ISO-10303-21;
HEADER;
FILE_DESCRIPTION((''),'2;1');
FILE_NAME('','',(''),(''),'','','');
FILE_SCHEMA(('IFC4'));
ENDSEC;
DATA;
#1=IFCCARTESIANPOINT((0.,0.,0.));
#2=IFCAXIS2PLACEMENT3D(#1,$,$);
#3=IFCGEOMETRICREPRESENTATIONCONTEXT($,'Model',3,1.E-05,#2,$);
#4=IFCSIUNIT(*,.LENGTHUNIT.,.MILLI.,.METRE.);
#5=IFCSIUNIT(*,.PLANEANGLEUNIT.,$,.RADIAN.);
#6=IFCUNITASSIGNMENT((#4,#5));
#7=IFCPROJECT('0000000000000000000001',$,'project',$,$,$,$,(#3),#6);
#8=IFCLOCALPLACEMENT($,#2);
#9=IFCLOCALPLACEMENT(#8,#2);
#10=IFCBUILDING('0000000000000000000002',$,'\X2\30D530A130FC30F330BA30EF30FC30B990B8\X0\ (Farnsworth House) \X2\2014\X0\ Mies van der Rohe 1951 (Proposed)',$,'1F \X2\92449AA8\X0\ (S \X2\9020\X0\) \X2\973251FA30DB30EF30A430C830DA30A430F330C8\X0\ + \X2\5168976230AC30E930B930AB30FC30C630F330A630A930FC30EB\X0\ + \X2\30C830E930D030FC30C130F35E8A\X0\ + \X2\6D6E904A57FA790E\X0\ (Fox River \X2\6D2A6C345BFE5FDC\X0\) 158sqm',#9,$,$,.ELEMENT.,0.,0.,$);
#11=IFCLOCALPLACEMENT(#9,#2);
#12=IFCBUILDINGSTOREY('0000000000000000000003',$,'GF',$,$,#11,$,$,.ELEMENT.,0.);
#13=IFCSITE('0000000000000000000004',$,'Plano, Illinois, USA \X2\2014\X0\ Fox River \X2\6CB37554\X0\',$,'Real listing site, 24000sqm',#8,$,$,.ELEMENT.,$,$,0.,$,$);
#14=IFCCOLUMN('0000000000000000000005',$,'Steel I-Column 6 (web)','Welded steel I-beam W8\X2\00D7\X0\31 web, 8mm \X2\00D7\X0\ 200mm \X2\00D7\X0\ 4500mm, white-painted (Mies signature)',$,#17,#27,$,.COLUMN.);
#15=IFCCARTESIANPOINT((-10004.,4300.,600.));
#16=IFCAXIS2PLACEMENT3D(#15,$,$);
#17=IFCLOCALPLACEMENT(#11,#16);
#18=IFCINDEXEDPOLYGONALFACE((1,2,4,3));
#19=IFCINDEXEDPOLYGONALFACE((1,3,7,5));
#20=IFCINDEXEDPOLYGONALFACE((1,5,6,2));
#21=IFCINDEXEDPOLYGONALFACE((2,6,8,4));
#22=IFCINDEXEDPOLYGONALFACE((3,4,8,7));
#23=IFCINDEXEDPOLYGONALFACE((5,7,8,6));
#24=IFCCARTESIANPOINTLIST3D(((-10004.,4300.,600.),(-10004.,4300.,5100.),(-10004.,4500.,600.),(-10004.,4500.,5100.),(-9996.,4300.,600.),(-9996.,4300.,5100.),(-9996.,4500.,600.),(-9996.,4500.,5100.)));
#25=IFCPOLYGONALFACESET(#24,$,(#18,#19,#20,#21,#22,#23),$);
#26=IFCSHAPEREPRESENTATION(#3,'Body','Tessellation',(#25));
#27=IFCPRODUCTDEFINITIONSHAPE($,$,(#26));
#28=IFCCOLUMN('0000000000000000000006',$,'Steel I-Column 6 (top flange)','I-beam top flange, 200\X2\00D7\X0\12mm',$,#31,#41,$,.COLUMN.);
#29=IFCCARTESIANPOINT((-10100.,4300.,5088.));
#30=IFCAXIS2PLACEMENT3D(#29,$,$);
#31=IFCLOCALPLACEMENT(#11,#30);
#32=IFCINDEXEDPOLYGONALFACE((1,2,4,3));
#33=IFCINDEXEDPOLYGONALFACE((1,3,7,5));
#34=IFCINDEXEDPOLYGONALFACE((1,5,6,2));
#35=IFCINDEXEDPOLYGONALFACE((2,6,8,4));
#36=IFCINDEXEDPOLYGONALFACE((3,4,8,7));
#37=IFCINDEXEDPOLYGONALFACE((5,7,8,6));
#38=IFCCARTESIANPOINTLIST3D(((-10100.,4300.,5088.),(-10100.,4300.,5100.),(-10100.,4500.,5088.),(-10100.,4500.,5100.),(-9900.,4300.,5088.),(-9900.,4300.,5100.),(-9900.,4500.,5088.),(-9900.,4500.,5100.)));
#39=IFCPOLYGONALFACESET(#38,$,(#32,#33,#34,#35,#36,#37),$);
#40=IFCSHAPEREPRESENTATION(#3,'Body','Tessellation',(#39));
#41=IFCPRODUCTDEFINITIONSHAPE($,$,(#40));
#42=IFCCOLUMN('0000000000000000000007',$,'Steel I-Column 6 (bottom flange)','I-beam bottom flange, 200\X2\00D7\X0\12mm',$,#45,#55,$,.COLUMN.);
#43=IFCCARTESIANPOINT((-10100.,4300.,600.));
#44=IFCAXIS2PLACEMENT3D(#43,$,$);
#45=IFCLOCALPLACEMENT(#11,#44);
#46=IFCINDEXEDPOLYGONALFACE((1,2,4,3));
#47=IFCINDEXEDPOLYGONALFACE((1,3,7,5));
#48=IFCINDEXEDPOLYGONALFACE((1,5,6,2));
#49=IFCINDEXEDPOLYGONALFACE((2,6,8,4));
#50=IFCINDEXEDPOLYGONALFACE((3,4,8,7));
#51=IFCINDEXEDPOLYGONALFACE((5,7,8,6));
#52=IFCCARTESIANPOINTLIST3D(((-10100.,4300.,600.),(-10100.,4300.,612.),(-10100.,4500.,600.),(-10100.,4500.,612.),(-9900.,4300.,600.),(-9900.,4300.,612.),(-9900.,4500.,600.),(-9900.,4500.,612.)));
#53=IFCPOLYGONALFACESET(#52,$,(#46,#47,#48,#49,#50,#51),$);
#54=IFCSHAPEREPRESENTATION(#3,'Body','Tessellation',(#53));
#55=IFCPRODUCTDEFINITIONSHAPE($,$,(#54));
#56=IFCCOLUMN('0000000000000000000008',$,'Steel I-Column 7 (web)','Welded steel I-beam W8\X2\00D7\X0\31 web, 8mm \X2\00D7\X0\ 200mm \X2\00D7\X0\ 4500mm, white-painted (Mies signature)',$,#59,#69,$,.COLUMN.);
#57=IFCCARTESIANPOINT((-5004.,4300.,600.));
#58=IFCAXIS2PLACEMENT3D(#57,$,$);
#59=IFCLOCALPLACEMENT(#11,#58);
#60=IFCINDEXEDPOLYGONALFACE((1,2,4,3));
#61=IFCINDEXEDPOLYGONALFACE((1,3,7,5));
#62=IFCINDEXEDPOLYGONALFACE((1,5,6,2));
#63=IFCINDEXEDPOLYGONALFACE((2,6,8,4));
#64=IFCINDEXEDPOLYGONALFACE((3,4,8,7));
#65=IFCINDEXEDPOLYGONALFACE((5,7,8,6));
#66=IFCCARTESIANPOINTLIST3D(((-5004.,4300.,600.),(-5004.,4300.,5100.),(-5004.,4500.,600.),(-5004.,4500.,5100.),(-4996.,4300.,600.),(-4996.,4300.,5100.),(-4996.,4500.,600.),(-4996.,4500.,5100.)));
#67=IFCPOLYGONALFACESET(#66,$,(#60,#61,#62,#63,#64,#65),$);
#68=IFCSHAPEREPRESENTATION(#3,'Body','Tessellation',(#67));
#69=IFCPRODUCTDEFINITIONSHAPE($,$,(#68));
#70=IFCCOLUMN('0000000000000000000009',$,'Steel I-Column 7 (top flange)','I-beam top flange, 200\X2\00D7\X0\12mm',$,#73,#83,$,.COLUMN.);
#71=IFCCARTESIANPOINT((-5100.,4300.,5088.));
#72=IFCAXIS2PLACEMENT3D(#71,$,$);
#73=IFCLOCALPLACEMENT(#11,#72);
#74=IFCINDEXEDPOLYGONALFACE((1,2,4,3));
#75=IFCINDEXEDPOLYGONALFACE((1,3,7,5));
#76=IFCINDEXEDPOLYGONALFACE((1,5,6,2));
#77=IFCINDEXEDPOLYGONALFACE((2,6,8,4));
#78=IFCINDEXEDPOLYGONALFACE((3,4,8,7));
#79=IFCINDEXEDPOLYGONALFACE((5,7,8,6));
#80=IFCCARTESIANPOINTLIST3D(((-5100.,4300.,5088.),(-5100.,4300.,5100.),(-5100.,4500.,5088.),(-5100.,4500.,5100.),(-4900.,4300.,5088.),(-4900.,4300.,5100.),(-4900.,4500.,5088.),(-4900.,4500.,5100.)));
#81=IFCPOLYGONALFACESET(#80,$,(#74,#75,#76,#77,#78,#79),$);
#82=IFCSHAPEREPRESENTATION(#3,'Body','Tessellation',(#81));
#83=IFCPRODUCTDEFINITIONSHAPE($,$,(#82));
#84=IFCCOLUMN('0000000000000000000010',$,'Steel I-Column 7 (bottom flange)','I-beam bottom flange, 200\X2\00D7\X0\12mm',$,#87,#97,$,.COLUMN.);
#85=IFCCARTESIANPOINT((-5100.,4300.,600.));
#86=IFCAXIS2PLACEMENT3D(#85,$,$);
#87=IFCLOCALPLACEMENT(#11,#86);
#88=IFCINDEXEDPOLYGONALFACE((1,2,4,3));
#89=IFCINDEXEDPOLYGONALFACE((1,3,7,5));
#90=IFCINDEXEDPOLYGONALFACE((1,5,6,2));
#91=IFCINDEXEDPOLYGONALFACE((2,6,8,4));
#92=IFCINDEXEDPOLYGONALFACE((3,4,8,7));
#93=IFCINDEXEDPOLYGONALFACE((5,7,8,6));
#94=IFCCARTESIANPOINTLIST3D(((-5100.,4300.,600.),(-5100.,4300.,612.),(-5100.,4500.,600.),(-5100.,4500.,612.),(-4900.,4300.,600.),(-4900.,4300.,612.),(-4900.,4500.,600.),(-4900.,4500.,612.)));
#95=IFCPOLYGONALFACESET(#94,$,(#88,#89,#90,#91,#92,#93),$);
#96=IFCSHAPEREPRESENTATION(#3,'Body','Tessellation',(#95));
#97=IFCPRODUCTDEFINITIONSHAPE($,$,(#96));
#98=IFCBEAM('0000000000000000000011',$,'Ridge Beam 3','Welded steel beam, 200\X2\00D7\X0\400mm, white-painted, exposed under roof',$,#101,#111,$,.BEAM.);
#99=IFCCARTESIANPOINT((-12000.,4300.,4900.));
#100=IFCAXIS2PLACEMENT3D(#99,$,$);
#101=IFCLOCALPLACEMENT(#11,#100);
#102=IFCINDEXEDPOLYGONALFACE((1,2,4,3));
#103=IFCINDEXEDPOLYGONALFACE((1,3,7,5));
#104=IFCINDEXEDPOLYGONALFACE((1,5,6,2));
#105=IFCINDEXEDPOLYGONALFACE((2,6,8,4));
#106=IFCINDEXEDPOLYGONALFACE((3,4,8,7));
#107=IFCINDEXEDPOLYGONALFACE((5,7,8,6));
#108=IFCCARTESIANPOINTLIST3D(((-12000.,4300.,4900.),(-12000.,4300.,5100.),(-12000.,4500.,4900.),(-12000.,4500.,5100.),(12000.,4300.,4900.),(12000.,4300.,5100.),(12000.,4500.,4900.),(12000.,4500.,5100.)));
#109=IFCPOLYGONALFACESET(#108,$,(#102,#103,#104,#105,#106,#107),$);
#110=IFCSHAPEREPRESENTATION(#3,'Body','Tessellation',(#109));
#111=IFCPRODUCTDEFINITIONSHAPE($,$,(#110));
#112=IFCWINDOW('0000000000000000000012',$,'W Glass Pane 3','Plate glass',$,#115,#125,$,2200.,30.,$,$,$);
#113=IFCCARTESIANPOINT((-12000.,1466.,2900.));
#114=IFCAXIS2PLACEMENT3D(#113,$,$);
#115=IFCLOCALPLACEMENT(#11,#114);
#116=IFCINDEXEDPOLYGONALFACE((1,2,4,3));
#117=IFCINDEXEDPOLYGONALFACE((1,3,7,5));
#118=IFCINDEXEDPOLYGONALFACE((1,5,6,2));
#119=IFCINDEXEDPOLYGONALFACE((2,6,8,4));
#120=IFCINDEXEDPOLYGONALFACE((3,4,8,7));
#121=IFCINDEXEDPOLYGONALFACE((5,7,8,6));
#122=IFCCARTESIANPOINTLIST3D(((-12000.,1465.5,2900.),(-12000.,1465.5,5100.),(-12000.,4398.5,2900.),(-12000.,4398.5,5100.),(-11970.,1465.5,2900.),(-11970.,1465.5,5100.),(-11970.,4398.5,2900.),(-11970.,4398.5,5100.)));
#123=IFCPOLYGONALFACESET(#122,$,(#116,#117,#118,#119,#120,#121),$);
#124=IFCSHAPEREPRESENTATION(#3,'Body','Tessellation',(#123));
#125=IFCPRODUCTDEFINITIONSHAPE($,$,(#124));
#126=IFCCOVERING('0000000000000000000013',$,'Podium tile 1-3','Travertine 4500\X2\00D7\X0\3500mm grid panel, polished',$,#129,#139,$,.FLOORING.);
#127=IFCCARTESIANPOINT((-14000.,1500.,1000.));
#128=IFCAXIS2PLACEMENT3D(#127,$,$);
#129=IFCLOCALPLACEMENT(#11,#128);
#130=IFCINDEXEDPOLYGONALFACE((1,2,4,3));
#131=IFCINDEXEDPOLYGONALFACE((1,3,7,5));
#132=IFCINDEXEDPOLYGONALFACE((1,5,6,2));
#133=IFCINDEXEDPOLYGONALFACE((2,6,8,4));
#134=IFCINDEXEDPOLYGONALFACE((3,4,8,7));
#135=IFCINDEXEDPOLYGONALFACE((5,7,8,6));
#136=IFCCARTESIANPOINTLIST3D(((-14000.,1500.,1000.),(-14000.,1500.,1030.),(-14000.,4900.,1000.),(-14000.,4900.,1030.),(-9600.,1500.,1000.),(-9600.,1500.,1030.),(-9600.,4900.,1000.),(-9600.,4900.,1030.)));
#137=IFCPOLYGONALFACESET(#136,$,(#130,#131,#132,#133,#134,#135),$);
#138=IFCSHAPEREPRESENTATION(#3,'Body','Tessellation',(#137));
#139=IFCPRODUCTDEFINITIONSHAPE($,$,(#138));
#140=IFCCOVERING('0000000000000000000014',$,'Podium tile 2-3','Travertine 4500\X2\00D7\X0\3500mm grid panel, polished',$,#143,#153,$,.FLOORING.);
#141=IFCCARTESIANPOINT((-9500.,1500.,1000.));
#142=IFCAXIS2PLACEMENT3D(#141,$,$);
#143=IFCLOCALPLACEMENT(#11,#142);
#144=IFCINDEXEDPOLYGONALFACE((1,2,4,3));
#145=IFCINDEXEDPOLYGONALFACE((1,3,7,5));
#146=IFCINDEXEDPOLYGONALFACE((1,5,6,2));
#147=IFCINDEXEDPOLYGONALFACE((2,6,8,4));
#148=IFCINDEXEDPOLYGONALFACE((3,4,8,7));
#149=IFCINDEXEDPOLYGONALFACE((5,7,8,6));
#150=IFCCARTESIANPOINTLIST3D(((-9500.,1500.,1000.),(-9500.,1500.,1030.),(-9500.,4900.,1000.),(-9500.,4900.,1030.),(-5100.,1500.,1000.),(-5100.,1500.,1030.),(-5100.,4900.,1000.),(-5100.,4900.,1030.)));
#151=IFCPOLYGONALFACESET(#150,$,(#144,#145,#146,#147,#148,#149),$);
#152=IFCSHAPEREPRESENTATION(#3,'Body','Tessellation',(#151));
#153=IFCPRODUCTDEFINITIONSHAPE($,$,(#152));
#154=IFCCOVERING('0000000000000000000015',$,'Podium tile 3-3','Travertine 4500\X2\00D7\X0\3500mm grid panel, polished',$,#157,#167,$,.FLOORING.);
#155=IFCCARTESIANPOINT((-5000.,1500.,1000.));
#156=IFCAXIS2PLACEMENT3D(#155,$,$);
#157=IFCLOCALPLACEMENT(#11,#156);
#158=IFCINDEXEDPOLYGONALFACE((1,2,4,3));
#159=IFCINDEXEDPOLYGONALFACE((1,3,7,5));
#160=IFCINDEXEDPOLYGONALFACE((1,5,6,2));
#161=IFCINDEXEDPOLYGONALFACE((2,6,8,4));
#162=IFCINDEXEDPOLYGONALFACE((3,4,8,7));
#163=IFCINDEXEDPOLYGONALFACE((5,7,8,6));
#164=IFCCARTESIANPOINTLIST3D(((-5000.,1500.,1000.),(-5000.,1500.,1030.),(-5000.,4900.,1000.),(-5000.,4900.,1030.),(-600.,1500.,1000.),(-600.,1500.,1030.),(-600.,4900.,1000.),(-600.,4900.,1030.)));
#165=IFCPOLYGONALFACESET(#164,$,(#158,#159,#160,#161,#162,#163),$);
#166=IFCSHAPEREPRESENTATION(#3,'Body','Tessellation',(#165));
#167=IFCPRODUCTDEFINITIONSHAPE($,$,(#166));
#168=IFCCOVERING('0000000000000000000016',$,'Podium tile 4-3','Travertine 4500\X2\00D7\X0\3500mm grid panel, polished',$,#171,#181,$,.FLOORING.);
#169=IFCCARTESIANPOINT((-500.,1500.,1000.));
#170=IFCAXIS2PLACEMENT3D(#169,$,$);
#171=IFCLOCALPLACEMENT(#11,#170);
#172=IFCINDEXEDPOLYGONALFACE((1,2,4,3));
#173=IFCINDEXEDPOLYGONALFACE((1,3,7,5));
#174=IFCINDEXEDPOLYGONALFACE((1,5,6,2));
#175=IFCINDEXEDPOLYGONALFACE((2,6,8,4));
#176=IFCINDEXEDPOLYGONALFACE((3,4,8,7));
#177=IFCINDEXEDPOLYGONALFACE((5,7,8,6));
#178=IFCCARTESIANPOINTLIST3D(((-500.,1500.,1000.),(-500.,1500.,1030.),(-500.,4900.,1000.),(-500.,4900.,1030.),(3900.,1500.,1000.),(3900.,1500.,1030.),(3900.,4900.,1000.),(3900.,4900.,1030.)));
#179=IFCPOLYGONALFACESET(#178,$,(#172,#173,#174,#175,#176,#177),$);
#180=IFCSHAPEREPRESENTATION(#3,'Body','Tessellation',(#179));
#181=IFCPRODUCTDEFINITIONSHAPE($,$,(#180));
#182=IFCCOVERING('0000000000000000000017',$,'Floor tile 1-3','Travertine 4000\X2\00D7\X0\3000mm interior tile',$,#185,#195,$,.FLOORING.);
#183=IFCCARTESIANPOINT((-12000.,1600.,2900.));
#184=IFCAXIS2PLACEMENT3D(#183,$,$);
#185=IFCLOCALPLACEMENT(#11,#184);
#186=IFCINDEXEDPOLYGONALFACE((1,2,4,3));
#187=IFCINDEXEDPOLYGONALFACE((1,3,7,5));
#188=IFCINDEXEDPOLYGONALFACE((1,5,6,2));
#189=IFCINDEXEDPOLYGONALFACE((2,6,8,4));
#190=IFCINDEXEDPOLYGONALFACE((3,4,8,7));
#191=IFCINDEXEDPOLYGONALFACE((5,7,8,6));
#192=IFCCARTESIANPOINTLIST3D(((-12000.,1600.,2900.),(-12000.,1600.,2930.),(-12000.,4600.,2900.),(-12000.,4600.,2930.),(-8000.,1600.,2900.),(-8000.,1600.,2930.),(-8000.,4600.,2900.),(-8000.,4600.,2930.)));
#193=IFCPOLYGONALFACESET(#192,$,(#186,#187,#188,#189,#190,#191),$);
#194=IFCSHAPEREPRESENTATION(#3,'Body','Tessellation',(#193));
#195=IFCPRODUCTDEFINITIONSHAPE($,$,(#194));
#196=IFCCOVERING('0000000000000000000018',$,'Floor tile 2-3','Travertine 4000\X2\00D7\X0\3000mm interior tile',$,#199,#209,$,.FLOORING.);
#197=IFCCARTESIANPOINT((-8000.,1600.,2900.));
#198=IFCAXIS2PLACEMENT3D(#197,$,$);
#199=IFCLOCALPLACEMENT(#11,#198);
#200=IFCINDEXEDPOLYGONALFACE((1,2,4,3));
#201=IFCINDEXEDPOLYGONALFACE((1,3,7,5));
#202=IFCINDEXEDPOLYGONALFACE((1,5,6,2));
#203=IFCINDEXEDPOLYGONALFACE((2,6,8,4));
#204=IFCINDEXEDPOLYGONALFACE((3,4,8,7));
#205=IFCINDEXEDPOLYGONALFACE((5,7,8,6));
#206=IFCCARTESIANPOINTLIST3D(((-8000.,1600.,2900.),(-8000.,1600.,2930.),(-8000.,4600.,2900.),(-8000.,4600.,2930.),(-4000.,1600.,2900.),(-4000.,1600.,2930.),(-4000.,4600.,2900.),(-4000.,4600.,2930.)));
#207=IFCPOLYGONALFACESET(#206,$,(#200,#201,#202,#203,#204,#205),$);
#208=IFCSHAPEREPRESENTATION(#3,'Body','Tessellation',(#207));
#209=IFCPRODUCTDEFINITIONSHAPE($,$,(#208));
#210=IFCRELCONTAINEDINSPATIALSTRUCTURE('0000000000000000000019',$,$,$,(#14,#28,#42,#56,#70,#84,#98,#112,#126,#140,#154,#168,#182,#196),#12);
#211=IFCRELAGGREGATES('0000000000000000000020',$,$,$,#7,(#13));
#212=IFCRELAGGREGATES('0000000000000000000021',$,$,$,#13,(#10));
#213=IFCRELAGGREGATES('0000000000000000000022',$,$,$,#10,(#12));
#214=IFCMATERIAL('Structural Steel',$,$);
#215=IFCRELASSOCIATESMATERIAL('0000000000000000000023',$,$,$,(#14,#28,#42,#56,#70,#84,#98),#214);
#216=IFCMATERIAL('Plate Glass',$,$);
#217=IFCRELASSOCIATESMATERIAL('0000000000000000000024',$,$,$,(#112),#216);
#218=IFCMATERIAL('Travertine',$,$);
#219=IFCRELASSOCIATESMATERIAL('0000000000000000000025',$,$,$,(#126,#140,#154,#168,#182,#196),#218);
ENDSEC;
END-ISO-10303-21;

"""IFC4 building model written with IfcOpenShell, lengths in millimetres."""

from ifc_helpers import new_model, si_unit, frame, frame_2d, origin, place, context, project, spatial, rectangle, extrude, material, element, save


model = new_model("IFC4")

# Units and contexts
model_context = context("Model", 3, precision=1e-05, world=origin())
ifc_project = project(units=[si_unit("LENGTHUNIT", "METRE", prefix="MILLI"), si_unit("PLANEANGLEUNIT", "RADIAN")], contexts=[model_context])

# Site, building, storey
site_placement = place(None, origin())
site = spatial("IfcSite", under=ifc_project, at=site_placement, Name="Plano, Illinois, USA — Fox River 河畔", ObjectType="Real listing site, 24000sqm", CompositionType="ELEMENT", RefElevation=0.0)
building_placement = place(site_placement, origin())
building = spatial("IfcBuilding", under=site, at=building_placement, Name="ファーンズワース邸 (Farnsworth House) — Mies van der Rohe 1951 (Proposed)", ObjectType="1F 鉄骨 (S 造) 露出ホワイトペイント + 全面ガラスカーテンウォール + トラバーチン床 + 浮遊基礎 (Fox River 洪水対応) 158sqm", CompositionType="ELEMENT", ElevationOfRefHeight=0.0, ElevationOfTerrain=0.0)
storey_placement = place(building_placement, origin())
storey = spatial("IfcBuildingStorey", under=building, at=storey_placement, Name="GF", CompositionType="ELEMENT", Elevation=0.0)

# Columns
ifc_material_1 = material(Name="Structural Steel")
column_1_placement = place(storey_placement, frame((-10004.0, 4300.0, 600.0)))
element("IfcColumn", 1, at=column_1_placement, inside=storey, material=ifc_material_1, Name="Steel I-Column 6 (web)", Description="Welded steel I-beam W8×31 web, 8mm × 200mm × 4500mm, white-painted (Mies signature)", PredefinedType="COLUMN", context=model_context, shape_type="SweptSolid", body=[
    extrude(rectangle(XDim=8.0, YDim=200.0, at=frame_2d((4.0, 100.0))), frame((-10004.0, 4300.0, 600.0)), (0.0, 0.0, 1.0), 4500.0),
])
column_2_placement = place(storey_placement, frame((-10100.0, 4300.0, 5088.0)))
element("IfcColumn", 2, at=column_2_placement, inside=storey, material=ifc_material_1, Name="Steel I-Column 6 (top flange)", Description="I-beam top flange, 200×12mm", PredefinedType="COLUMN", context=model_context, shape_type="SweptSolid", body=[
    extrude(rectangle(XDim=200.0, YDim=200.0, at=frame_2d((100.0, 100.0))), frame((-10100.0, 4300.0, 5088.0)), (0.0, 0.0, 1.0), 12.0),
])
column_3_placement = place(storey_placement, frame((-10100.0, 4300.0, 600.0)))
element("IfcColumn", 3, at=column_3_placement, inside=storey, material=ifc_material_1, Name="Steel I-Column 6 (bottom flange)", Description="I-beam bottom flange, 200×12mm", PredefinedType="COLUMN", context=model_context, shape_type="SweptSolid", body=[
    extrude(rectangle(XDim=200.0, YDim=200.0, at=frame_2d((100.0, 100.0))), frame((-10100.0, 4300.0, 600.0)), (0.0, 0.0, 1.0), 12.0),
])
column_4_placement = place(storey_placement, frame((-5004.0, 4300.0, 600.0)))
element("IfcColumn", 4, at=column_4_placement, inside=storey, material=ifc_material_1, Name="Steel I-Column 7 (web)", Description="Welded steel I-beam W8×31 web, 8mm × 200mm × 4500mm, white-painted (Mies signature)", PredefinedType="COLUMN", context=model_context, shape_type="SweptSolid", body=[
    extrude(rectangle(XDim=8.0, YDim=200.0, at=frame_2d((4.0, 100.0))), frame((-5004.0, 4300.0, 600.0)), (0.0, 0.0, 1.0), 4500.0),
])
column_5_placement = place(storey_placement, frame((-5100.0, 4300.0, 5088.0)))
element("IfcColumn", 5, at=column_5_placement, inside=storey, material=ifc_material_1, Name="Steel I-Column 7 (top flange)", Description="I-beam top flange, 200×12mm", PredefinedType="COLUMN", context=model_context, shape_type="SweptSolid", body=[
    extrude(rectangle(XDim=200.0, YDim=200.0, at=frame_2d((100.0, 100.0))), frame((-5100.0, 4300.0, 5088.0)), (0.0, 0.0, 1.0), 12.0),
])
column_6_placement = place(storey_placement, frame((-5100.0, 4300.0, 600.0)))
element("IfcColumn", 6, at=column_6_placement, inside=storey, material=ifc_material_1, Name="Steel I-Column 7 (bottom flange)", Description="I-beam bottom flange, 200×12mm", PredefinedType="COLUMN", context=model_context, shape_type="SweptSolid", body=[
    extrude(rectangle(XDim=200.0, YDim=200.0, at=frame_2d((100.0, 100.0))), frame((-5100.0, 4300.0, 600.0)), (0.0, 0.0, 1.0), 12.0),
])

# Beam
beam_1_placement = place(storey_placement, frame((-12000.0, 4300.0, 4900.0)))
element("IfcBeam", 7, at=beam_1_placement, inside=storey, material=ifc_material_1, Name="Ridge Beam 3", Description="Welded steel beam, 200×400mm, white-painted, exposed under roof", PredefinedType="BEAM", context=model_context, shape_type="SweptSolid", body=[
    extrude(rectangle(XDim=24000.0, YDim=200.0, at=frame_2d((12000.0, 100.0))), frame((-12000.0, 4300.0, 4900.0)), (0.0, 0.0, 1.0), 200.0),
])

# Window
ifc_material_2 = material(Name="Plate Glass")
window_placement = place(storey_placement, frame((-12000.0, 1466.0, 2900.0)))
element("IfcWindow", 8, at=window_placement, inside=storey, material=ifc_material_2, Name="W Glass Pane 3", Description="Plate glass", OverallHeight=2200.0, OverallWidth=30.0, context=model_context, shape_type="SweptSolid", body=[
    extrude(rectangle(XDim=30.0, YDim=2933.0, at=frame_2d((15.0, 1466.0))), frame((-12000.0, 1466.0, 2900.0)), (0.0, 0.0, 1.0), 2200.0),
])

# Coverings
ifc_material_3 = material(Name="Travertine")
covering_1_placement = place(storey_placement, frame((-14000.0, 1500.0, 1000.0)))
element("IfcCovering", 9, at=covering_1_placement, inside=storey, material=ifc_material_3, Name="Podium tile 1-3", Description="Travertine 4500×3500mm grid panel, polished", PredefinedType="FLOORING", context=model_context, shape_type="SweptSolid", body=[
    extrude(rectangle(XDim=4400.0, YDim=3400.0, at=frame_2d((2200.0, 1700.0))), frame((-14000.0, 1500.0, 1000.0)), (0.0, 0.0, 1.0), 30.0),
])
covering_2_placement = place(storey_placement, frame((-9500.0, 1500.0, 1000.0)))
element("IfcCovering", 10, at=covering_2_placement, inside=storey, material=ifc_material_3, Name="Podium tile 2-3", Description="Travertine 4500×3500mm grid panel, polished", PredefinedType="FLOORING", context=model_context, shape_type="SweptSolid", body=[
    extrude(rectangle(XDim=4400.0, YDim=3400.0, at=frame_2d((2200.0, 1700.0))), frame((-9500.0, 1500.0, 1000.0)), (0.0, 0.0, 1.0), 30.0),
])
covering_3_placement = place(storey_placement, frame((-5000.0, 1500.0, 1000.0)))
element("IfcCovering", 11, at=covering_3_placement, inside=storey, material=ifc_material_3, Name="Podium tile 3-3", Description="Travertine 4500×3500mm grid panel, polished", PredefinedType="FLOORING", context=model_context, shape_type="SweptSolid", body=[
    extrude(rectangle(XDim=4400.0, YDim=3400.0, at=frame_2d((2200.0, 1700.0))), frame((-5000.0, 1500.0, 1000.0)), (0.0, 0.0, 1.0), 30.0),
])
covering_4_placement = place(storey_placement, frame((-500.0, 1500.0, 1000.0)))
element("IfcCovering", 12, at=covering_4_placement, inside=storey, material=ifc_material_3, Name="Podium tile 4-3", Description="Travertine 4500×3500mm grid panel, polished", PredefinedType="FLOORING", context=model_context, shape_type="SweptSolid", body=[
    extrude(rectangle(XDim=4400.0, YDim=3400.0, at=frame_2d((2200.0, 1700.0))), frame((-500.0, 1500.0, 1000.0)), (0.0, 0.0, 1.0), 30.0),
])
covering_5_placement = place(storey_placement, frame((-12000.0, 1600.0, 2900.0)))
element("IfcCovering", 13, at=covering_5_placement, inside=storey, material=ifc_material_3, Name="Floor tile 1-3", Description="Travertine 4000×3000mm interior tile", PredefinedType="FLOORING", context=model_context, shape_type="SweptSolid", body=[
    extrude(rectangle(XDim=4000.0, YDim=3000.0, at=frame_2d((2000.0, 1500.0))), frame((-12000.0, 1600.0, 2900.0)), (0.0, 0.0, 1.0), 30.0),
])
covering_6_placement = place(storey_placement, frame((-8000.0, 1600.0, 2900.0)))
element("IfcCovering", 14, at=covering_6_placement, inside=storey, material=ifc_material_3, Name="Floor tile 2-3", Description="Travertine 4000×3000mm interior tile", PredefinedType="FLOORING", context=model_context, shape_type="SweptSolid", body=[
    extrude(rectangle(XDim=4000.0, YDim=3000.0, at=frame_2d((2000.0, 1500.0))), frame((-8000.0, 1600.0, 2900.0)), (0.0, 0.0, 1.0), 30.0),
])

save(model, "model.ifc")
